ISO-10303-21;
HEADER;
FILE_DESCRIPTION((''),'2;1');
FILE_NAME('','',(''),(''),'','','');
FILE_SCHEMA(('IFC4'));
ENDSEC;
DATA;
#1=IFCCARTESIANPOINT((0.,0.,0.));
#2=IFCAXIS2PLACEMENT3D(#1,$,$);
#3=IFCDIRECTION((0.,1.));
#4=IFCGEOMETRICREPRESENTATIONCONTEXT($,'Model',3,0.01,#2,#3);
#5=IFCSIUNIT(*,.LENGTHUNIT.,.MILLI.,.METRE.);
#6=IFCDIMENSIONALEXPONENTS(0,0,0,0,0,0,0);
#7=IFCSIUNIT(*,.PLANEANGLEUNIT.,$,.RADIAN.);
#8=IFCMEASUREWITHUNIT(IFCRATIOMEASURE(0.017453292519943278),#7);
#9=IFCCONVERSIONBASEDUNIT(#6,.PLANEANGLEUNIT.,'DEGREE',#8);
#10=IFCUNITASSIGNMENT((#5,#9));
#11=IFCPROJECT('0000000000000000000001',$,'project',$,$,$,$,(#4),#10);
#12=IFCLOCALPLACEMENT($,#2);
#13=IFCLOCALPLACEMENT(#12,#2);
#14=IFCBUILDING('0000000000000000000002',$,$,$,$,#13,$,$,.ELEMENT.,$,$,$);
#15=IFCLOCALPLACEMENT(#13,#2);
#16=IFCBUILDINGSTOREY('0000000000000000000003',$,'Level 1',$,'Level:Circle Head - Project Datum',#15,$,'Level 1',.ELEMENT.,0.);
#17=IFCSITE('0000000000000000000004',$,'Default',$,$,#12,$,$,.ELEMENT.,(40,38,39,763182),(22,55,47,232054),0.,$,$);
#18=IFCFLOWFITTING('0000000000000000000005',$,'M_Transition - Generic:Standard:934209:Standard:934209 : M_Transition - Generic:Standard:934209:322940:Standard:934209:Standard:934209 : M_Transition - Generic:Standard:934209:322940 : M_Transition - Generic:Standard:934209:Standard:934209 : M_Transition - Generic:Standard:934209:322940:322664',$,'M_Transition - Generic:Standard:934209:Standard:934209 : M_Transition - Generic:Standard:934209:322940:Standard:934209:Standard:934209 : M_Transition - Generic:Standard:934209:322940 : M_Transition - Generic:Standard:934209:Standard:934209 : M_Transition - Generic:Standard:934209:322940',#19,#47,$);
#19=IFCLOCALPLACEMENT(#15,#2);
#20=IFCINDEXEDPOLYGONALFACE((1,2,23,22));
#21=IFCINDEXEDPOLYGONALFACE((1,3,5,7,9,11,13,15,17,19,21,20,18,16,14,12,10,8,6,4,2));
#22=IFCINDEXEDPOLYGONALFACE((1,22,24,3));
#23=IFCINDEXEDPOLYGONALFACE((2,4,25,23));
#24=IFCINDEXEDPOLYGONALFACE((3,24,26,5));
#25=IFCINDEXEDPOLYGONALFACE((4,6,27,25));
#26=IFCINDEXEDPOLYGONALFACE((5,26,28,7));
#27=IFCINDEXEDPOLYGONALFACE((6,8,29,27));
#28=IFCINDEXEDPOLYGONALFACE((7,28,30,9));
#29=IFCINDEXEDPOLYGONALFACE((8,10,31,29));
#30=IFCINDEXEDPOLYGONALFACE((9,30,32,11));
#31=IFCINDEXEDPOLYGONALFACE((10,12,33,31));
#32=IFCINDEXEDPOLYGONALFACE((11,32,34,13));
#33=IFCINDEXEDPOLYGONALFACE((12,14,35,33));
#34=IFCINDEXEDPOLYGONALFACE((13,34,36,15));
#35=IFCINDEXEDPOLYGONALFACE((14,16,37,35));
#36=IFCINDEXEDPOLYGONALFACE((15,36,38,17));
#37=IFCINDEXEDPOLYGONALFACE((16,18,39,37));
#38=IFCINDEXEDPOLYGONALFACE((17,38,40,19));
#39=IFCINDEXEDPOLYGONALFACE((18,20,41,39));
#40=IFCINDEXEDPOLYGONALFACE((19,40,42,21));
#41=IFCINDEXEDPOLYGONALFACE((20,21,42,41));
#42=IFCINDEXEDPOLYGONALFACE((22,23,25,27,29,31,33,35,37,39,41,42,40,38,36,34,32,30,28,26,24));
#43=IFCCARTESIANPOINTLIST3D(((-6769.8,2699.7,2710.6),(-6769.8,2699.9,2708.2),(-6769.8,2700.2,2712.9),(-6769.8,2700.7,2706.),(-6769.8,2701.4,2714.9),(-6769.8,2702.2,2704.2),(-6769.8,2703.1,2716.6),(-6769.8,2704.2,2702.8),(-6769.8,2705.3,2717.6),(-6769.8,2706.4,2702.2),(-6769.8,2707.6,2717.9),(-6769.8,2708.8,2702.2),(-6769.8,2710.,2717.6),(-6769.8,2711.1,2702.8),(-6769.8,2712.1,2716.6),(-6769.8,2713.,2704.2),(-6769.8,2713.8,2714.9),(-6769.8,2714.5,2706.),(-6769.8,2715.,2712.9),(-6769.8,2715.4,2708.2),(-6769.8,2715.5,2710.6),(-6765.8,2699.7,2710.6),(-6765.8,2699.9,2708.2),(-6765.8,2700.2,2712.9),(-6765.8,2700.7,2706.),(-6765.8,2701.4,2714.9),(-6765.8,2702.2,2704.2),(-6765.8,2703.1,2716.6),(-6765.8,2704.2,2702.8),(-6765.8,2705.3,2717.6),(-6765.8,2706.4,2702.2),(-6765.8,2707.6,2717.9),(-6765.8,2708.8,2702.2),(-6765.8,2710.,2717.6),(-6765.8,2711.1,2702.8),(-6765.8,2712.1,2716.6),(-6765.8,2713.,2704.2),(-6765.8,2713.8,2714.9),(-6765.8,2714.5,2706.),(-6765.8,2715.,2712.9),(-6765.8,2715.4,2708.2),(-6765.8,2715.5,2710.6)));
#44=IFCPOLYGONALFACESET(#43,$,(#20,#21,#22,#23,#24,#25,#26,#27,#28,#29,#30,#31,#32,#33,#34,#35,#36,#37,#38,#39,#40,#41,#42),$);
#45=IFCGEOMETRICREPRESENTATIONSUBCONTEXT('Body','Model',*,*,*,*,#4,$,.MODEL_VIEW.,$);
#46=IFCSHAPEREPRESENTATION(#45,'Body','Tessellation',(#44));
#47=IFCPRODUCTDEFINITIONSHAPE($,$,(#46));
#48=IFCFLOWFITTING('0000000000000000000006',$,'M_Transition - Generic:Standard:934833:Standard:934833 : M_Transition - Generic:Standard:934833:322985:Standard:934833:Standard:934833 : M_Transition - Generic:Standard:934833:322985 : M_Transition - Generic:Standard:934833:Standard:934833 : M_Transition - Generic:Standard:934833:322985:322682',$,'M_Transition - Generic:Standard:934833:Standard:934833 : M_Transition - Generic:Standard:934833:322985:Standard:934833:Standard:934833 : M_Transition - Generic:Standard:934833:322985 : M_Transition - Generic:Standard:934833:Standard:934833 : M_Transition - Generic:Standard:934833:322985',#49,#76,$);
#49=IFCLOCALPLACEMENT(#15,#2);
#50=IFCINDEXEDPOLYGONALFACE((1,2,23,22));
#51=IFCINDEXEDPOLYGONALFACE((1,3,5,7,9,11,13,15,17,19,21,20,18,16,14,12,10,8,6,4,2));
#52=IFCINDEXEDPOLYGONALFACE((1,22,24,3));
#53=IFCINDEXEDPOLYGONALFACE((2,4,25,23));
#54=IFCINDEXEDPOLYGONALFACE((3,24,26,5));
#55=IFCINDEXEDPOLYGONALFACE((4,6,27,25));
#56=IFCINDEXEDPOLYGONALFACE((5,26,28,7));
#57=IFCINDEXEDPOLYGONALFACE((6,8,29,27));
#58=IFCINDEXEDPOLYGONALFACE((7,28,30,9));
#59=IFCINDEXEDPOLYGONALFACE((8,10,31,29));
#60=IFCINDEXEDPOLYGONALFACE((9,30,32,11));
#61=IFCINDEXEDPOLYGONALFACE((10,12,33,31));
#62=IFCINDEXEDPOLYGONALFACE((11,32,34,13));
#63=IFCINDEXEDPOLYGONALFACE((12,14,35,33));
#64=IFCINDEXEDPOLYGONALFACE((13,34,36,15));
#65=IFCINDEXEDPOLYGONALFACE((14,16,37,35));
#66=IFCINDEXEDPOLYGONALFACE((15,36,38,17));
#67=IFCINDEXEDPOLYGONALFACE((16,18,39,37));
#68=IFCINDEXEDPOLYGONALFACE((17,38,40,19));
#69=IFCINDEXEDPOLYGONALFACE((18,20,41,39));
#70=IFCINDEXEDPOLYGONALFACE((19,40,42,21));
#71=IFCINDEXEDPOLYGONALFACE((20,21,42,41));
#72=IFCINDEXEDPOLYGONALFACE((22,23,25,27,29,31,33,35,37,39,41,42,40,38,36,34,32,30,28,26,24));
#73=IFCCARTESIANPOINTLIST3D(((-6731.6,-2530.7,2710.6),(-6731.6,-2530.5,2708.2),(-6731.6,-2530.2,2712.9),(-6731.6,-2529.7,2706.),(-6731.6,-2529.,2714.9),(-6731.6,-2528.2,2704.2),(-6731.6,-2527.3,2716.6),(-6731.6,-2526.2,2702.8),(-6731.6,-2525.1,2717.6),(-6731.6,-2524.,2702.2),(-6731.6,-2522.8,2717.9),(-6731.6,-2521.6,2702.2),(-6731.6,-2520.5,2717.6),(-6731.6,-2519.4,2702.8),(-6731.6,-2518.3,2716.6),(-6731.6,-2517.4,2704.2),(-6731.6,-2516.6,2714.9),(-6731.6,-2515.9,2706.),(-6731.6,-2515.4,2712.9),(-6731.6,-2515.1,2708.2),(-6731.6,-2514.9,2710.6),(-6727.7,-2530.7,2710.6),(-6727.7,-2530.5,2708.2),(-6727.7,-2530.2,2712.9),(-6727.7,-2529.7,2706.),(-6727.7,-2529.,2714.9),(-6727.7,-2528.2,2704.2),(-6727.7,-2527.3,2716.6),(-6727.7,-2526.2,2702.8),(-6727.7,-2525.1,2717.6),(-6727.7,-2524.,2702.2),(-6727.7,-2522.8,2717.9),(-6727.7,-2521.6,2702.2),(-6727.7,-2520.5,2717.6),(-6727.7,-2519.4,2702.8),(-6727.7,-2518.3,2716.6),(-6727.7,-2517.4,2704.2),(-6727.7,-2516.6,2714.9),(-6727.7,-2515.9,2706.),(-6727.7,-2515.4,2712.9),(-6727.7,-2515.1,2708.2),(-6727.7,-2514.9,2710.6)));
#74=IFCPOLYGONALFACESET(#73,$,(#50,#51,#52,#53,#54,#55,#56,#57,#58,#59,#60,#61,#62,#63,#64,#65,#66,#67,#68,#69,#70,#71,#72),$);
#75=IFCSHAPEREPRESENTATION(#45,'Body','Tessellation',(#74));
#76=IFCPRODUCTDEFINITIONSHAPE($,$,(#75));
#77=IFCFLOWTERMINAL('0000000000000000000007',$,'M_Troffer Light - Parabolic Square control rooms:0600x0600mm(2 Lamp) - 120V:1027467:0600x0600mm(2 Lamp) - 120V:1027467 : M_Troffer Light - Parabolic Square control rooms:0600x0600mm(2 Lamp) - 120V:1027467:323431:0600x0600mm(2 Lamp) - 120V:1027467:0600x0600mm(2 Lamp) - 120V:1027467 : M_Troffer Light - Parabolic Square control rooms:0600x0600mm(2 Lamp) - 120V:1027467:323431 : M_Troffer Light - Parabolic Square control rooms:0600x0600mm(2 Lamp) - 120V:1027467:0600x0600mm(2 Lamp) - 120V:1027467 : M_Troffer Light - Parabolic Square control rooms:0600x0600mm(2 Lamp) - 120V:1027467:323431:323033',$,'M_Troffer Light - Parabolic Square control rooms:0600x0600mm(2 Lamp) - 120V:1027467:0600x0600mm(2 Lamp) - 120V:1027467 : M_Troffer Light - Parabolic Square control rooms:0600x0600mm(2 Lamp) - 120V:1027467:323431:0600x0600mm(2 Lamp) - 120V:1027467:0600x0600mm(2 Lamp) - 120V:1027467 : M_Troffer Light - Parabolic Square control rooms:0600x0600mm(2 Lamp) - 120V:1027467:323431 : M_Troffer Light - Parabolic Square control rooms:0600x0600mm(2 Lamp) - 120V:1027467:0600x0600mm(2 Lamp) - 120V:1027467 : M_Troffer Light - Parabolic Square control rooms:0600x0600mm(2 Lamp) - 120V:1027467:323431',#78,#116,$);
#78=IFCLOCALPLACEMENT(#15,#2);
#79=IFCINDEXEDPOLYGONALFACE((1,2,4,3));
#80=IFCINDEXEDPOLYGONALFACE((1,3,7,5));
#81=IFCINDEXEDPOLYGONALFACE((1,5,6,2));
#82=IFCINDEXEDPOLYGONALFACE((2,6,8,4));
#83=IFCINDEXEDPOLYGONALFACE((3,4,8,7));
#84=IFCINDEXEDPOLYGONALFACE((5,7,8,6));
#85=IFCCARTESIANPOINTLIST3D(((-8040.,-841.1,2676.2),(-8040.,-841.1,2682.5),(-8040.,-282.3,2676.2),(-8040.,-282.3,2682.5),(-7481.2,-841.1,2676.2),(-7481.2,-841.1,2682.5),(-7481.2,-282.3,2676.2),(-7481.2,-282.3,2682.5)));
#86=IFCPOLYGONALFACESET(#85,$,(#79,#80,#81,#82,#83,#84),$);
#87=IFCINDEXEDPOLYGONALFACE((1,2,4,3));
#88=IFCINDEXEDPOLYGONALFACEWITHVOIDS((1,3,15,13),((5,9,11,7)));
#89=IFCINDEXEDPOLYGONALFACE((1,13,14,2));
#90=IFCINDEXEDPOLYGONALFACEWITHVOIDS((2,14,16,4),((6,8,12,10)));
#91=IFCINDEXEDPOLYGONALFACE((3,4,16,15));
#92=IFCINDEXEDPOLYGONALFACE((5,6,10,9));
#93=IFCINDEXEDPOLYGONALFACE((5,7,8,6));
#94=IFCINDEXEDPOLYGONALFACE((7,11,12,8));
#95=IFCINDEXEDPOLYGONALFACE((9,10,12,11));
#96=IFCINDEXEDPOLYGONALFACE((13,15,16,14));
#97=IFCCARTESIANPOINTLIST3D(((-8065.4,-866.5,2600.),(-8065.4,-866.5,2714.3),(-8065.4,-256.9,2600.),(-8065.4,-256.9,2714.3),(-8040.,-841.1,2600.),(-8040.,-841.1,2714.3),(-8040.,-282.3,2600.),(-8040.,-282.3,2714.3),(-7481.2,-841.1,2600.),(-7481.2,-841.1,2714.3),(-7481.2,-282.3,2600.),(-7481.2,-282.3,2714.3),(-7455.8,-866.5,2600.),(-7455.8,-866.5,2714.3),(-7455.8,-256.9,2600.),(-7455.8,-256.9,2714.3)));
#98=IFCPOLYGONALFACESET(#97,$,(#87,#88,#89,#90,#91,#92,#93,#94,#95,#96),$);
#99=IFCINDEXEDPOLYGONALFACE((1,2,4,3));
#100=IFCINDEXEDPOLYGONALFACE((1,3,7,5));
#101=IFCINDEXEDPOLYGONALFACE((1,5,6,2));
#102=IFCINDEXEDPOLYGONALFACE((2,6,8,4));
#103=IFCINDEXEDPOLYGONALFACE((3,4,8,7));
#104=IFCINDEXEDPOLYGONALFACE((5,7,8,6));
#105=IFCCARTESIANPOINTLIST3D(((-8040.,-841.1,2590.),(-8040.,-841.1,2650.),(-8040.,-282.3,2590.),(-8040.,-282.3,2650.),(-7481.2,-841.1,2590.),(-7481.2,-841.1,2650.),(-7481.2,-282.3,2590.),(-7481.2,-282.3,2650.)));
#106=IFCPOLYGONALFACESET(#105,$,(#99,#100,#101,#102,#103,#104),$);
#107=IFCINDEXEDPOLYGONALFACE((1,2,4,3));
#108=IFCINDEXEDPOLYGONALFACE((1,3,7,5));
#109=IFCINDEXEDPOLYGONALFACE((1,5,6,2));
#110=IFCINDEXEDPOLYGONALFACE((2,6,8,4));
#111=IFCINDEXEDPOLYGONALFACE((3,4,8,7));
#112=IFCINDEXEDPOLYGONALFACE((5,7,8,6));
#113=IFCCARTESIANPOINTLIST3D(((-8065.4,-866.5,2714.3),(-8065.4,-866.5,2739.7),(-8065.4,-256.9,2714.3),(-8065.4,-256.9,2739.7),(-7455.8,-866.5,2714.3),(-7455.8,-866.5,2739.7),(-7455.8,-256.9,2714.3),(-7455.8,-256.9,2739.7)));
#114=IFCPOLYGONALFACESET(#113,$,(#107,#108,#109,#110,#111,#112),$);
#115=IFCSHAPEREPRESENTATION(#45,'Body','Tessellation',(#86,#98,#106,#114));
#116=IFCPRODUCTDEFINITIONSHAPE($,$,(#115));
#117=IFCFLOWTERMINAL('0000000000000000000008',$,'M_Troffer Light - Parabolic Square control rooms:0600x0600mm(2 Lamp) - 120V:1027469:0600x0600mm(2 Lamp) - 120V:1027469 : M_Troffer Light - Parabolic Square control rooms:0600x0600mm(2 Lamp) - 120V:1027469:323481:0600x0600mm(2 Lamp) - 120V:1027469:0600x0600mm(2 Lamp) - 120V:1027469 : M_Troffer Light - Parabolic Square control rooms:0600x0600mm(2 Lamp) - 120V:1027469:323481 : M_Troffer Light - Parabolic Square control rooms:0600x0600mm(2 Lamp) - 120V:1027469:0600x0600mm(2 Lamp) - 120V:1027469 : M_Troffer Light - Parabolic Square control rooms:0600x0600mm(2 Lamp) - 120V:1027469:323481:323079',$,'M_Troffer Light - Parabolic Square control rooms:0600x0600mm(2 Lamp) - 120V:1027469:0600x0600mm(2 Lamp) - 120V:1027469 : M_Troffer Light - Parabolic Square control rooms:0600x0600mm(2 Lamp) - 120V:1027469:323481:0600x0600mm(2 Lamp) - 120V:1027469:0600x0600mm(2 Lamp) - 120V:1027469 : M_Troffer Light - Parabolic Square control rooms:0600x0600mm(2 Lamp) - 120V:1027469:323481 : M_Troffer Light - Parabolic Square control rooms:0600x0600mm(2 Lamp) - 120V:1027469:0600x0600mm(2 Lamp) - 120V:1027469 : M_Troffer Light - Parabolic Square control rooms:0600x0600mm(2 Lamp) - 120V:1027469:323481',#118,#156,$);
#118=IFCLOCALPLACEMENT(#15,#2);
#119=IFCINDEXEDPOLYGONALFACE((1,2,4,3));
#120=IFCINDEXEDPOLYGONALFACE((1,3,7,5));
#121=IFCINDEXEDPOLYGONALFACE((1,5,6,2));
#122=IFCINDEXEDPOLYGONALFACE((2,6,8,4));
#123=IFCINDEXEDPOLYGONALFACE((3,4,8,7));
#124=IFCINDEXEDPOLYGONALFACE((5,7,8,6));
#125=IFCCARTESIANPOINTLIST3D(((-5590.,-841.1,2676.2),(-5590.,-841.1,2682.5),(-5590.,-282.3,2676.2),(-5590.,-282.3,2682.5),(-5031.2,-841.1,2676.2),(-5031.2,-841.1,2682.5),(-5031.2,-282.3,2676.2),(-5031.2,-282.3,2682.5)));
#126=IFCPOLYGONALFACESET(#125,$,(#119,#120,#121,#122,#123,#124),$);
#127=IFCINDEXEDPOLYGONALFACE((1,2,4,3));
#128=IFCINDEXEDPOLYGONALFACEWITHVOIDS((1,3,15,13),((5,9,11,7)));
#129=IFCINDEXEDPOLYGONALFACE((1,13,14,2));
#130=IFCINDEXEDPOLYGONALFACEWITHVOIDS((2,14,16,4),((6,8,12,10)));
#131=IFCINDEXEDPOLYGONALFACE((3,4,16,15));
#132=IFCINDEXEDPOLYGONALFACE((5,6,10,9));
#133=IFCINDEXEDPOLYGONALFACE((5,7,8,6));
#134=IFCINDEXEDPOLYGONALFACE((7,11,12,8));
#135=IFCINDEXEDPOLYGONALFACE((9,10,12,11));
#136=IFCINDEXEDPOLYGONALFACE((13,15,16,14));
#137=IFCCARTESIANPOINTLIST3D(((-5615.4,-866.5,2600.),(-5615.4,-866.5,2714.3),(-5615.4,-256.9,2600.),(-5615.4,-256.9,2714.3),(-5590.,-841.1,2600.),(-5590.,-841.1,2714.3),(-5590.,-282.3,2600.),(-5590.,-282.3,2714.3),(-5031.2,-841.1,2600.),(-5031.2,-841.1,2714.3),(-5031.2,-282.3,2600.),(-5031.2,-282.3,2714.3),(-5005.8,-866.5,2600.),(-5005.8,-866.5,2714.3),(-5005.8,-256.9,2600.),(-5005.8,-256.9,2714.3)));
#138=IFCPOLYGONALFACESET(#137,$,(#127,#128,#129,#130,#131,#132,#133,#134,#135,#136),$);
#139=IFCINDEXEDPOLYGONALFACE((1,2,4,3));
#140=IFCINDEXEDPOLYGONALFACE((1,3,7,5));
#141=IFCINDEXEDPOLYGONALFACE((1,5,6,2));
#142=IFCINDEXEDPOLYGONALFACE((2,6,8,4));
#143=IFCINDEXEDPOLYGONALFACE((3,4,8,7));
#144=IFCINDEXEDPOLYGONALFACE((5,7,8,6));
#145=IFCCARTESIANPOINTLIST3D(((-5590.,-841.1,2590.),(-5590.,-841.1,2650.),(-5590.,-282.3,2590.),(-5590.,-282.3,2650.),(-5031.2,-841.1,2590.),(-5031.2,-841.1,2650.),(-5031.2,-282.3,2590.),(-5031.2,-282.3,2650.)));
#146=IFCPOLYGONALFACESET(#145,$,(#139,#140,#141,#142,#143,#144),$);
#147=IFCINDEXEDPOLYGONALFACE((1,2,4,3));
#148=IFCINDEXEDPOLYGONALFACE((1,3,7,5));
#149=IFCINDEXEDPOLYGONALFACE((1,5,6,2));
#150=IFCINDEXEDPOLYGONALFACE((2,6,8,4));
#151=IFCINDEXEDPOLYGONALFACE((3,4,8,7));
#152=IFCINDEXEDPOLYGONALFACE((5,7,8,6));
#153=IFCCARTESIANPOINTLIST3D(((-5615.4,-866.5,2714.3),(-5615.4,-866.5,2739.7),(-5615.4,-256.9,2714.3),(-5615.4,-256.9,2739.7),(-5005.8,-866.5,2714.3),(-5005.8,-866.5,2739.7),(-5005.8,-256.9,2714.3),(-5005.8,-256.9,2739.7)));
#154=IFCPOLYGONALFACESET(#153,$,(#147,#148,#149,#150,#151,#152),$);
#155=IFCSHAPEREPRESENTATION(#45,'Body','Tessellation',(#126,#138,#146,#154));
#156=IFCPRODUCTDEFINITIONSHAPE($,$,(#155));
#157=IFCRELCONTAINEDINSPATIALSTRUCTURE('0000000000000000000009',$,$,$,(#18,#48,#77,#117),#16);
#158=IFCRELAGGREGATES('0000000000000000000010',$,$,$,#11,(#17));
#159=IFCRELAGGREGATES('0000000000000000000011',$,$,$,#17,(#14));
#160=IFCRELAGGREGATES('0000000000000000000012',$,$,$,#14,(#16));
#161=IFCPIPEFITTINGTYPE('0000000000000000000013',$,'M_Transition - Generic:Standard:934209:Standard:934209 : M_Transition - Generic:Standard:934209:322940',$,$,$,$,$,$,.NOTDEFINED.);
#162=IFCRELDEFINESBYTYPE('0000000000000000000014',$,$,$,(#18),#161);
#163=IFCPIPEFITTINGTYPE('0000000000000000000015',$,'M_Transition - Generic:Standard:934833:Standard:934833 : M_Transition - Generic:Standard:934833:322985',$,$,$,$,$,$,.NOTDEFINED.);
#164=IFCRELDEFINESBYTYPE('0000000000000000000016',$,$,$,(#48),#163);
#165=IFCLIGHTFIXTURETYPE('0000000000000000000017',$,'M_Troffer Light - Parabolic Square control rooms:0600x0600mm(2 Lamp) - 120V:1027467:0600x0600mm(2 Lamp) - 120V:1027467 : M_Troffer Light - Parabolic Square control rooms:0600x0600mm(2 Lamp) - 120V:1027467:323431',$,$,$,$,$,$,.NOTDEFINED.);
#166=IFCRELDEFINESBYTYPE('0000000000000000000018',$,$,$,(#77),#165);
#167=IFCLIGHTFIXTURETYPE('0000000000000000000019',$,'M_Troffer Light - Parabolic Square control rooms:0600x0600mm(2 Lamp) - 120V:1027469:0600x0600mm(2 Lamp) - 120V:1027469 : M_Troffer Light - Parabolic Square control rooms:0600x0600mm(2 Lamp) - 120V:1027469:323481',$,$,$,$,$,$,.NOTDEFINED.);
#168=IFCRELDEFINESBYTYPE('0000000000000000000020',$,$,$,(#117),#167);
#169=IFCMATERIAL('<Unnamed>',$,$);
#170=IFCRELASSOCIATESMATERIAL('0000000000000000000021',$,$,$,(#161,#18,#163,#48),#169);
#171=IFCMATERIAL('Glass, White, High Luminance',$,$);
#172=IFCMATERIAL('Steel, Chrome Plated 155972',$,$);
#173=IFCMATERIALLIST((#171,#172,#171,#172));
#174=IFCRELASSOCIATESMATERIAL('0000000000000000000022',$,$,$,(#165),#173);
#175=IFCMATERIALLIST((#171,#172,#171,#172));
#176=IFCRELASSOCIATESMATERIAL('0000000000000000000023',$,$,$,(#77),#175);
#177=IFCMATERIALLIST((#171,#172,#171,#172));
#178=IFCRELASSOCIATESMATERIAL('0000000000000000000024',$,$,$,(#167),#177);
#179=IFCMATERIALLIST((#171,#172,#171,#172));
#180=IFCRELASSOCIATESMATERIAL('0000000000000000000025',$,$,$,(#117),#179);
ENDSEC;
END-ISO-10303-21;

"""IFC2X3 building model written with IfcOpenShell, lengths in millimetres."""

from ifc_helpers import new_model, entity, si_unit, converted_unit, direction, frame, frame_2d, origin, origin_2d_with_axis, place, context, subcontext, project, spatial, polyline, rectangle, circle, outline, extrude, source, transform, mapped, material, material_list, type_object, type_shapes, element, save


model = new_model("IFC2X3")

# Units and contexts
model_context = context("Model", 3, precision=0.01, world=origin(), true_north=direction((0.0, 1.0)))
body_context = subcontext(model_context, "Body", "Model", "MODEL_VIEW")
ifc_project = project(units=[si_unit("LENGTHUNIT", "METRE", prefix="MILLI"), converted_unit("PLANEANGLEUNIT", "DEGREE", entity("IfcRatioMeasure", 0.017453292519943278), si_unit("PLANEANGLEUNIT", "RADIAN"), dimensions=[0, 0, 0, 0, 0, 0, 0])], contexts=[model_context])

# Site, building, storey
site_placement = place(None, origin())
site = spatial("IfcSite", under=ifc_project, at=site_placement, Name="Default", CompositionType="ELEMENT", RefLatitude=(40, 38, 39, 763182), RefLongitude=(22, 55, 47, 232054), RefElevation=0.0)
building_placement = place(site_placement, origin())
building = spatial("IfcBuilding", under=site, at=building_placement, CompositionType="ELEMENT")
storey_placement = place(building_placement, origin())
storey = spatial("IfcBuildingStorey", under=building, at=storey_placement, Name="Level 1", ObjectType="Level:Circle Head - Project Datum", LongName="Level 1", CompositionType="ELEMENT", Elevation=0.0)

# Flow fittings
ifc_material_1 = material(Name="<Unnamed>")
pipe_fitting_type_1 = type_object("IfcPipeFittingType", Name="M_Transition - Generic:Standard:934209:Standard:934209 : M_Transition - Generic:Standard:934209:322940", PredefinedType="NOTDEFINED", material=ifc_material_1)
shared_shape_1 = source(origin(), body_context, "Body", "SweptSolid", [
    extrude(circle(Radius=7.9, at=origin_2d_with_axis()), frame((-6769.8, 2707.6, 2710.0), z_axis=(1.0, 0.0, 0.0), x_axis=(0.0, 0.0, 1.0)), (0.0, 0.0, 1.0), 4.0),
])
type_shapes(pipe_fitting_type_1, [shared_shape_1])
flow_fitting_1_placement = place(storey_placement, origin())
element("IfcFlowFitting", 1, at=flow_fitting_1_placement, inside=storey, type_object=pipe_fitting_type_1, material=ifc_material_1, Name="M_Transition - Generic:Standard:934209:Standard:934209 : M_Transition - Generic:Standard:934209:322940:Standard:934209:Standard:934209 : M_Transition - Generic:Standard:934209:322940 : M_Transition - Generic:Standard:934209:Standard:934209 : M_Transition - Generic:Standard:934209:322940:322664", ObjectType="M_Transition - Generic:Standard:934209:Standard:934209 : M_Transition - Generic:Standard:934209:322940:Standard:934209:Standard:934209 : M_Transition - Generic:Standard:934209:322940 : M_Transition - Generic:Standard:934209:Standard:934209 : M_Transition - Generic:Standard:934209:322940", context=body_context, shape_type="MappedRepresentation", body=[
    mapped(shared_shape_1, transform((0.0, 0.0, 0.0), scale=1.0)),
])
pipe_fitting_type_2 = type_object("IfcPipeFittingType", Name="M_Transition - Generic:Standard:934833:Standard:934833 : M_Transition - Generic:Standard:934833:322985", PredefinedType="NOTDEFINED", material=ifc_material_1)
shared_shape_2 = source(origin(), body_context, "Body", "SweptSolid", [
    extrude(circle(Radius=7.9, at=origin_2d_with_axis()), frame((-6731.6, -2522.8, 2710.0), z_axis=(1.0, 0.0, 0.0), x_axis=(0.0, 0.0, 1.0)), (0.0, 0.0, 1.0), 4.0),
])
type_shapes(pipe_fitting_type_2, [shared_shape_2])
flow_fitting_2_placement = place(storey_placement, origin())
element("IfcFlowFitting", 2, at=flow_fitting_2_placement, inside=storey, type_object=pipe_fitting_type_2, material=ifc_material_1, Name="M_Transition - Generic:Standard:934833:Standard:934833 : M_Transition - Generic:Standard:934833:322985:Standard:934833:Standard:934833 : M_Transition - Generic:Standard:934833:322985 : M_Transition - Generic:Standard:934833:Standard:934833 : M_Transition - Generic:Standard:934833:322985:322682", ObjectType="M_Transition - Generic:Standard:934833:Standard:934833 : M_Transition - Generic:Standard:934833:322985:Standard:934833:Standard:934833 : M_Transition - Generic:Standard:934833:322985 : M_Transition - Generic:Standard:934833:Standard:934833 : M_Transition - Generic:Standard:934833:322985", context=body_context, shape_type="MappedRepresentation", body=[
    mapped(shared_shape_2, transform((0.0, 0.0, 0.0), scale=1.0)),
])

# Flow terminals
ifc_material_2 = material(Name="Glass, White, High Luminance")
ifc_material_3 = material(Name="Steel, Chrome Plated 155972")
ifc_material_list_1 = material_list([ifc_material_2, ifc_material_3, ifc_material_2, ifc_material_3])
ifc_material_list_2 = material_list([ifc_material_2, ifc_material_3, ifc_material_2, ifc_material_3])
light_fixture_type_1 = type_object("IfcLightFixtureType", Name="M_Troffer Light - Parabolic Square control rooms:0600x0600mm(2 Lamp) - 120V:1027467:0600x0600mm(2 Lamp) - 120V:1027467 : M_Troffer Light - Parabolic Square control rooms:0600x0600mm(2 Lamp) - 120V:1027467:323431", PredefinedType="NOTDEFINED", material=ifc_material_list_2)
shared_shape_3 = source(origin(), body_context, "Body", "SweptSolid", [
    extrude(rectangle(XDim=558.8, YDim=558.8, at=frame_2d((0.0, 0.0), x_axis=(1.0, 0.0))), frame((-7760.6, -561.7, 2676.2), z_axis=(0.0, 0.0, 1.0), x_axis=(0.0, 1.0, 0.0)), (0.0, 0.0, 1.0), 6.4),
    extrude(outline(polyline([(-304.8, -304.8), (304.8, -304.8), (304.8, 304.8), (-304.8, 304.8), (-304.8, -304.8)]), holes=[polyline([(279.4, 279.4), (279.4, -279.4), (-279.4, -279.4), (-279.4, 279.4), (279.4, 279.4)])]), frame((-7760.6, -561.7, 2600.0), z_axis=(0.0, 0.0, 1.0), x_axis=(0.0, -1.0, 0.0)), (0.0, 0.0, 1.0), 114.3),
    extrude(rectangle(XDim=558.8, YDim=558.8, at=frame_2d((0.0, 0.0), x_axis=(1.0, 0.0))), frame((-7760.6, -561.7, 2590.0), z_axis=(0.0, 0.0, 1.0), x_axis=(0.0, 1.0, 0.0)), (0.0, 0.0, 1.0), 60.0),
    extrude(rectangle(XDim=609.6, YDim=609.6, at=origin_2d_with_axis()), frame((-7760.6, -561.7, 2714.3), z_axis=(0.0, 0.0, 1.0), x_axis=(0.0, 1.0, 0.0)), (0.0, 0.0, 1.0), 25.4),
])
type_shapes(light_fixture_type_1, [shared_shape_3])
flow_terminal_1_placement = place(storey_placement, origin())
element("IfcFlowTerminal", 3, at=flow_terminal_1_placement, inside=storey, type_object=light_fixture_type_1, material=ifc_material_list_1, Name="M_Troffer Light - Parabolic Square control rooms:0600x0600mm(2 Lamp) - 120V:1027467:0600x0600mm(2 Lamp) - 120V:1027467 : M_Troffer Light - Parabolic Square control rooms:0600x0600mm(2 Lamp) - 120V:1027467:323431:0600x0600mm(2 Lamp) - 120V:1027467:0600x0600mm(2 Lamp) - 120V:1027467 : M_Troffer Light - Parabolic Square control rooms:0600x0600mm(2 Lamp) - 120V:1027467:323431 : M_Troffer Light - Parabolic Square control rooms:0600x0600mm(2 Lamp) - 120V:1027467:0600x0600mm(2 Lamp) - 120V:1027467 : M_Troffer Light - Parabolic Square control rooms:0600x0600mm(2 Lamp) - 120V:1027467:323431:323033", ObjectType="M_Troffer Light - Parabolic Square control rooms:0600x0600mm(2 Lamp) - 120V:1027467:0600x0600mm(2 Lamp) - 120V:1027467 : M_Troffer Light - Parabolic Square control rooms:0600x0600mm(2 Lamp) - 120V:1027467:323431:0600x0600mm(2 Lamp) - 120V:1027467:0600x0600mm(2 Lamp) - 120V:1027467 : M_Troffer Light - Parabolic Square control rooms:0600x0600mm(2 Lamp) - 120V:1027467:323431 : M_Troffer Light - Parabolic Square control rooms:0600x0600mm(2 Lamp) - 120V:1027467:0600x0600mm(2 Lamp) - 120V:1027467 : M_Troffer Light - Parabolic Square control rooms:0600x0600mm(2 Lamp) - 120V:1027467:323431", context=body_context, shape_type="MappedRepresentation", body=[
    mapped(shared_shape_3, transform((0.0, 0.0, 0.0), scale=1.0)),
])
ifc_material_list_3 = material_list([ifc_material_2, ifc_material_3, ifc_material_2, ifc_material_3])
ifc_material_list_4 = material_list([ifc_material_2, ifc_material_3, ifc_material_2, ifc_material_3])
light_fixture_type_2 = type_object("IfcLightFixtureType", Name="M_Troffer Light - Parabolic Square control rooms:0600x0600mm(2 Lamp) - 120V:1027469:0600x0600mm(2 Lamp) - 120V:1027469 : M_Troffer Light - Parabolic Square control rooms:0600x0600mm(2 Lamp) - 120V:1027469:323481", PredefinedType="NOTDEFINED", material=ifc_material_list_4)
shared_shape_4 = source(origin(), body_context, "Body", "SweptSolid", [
    extrude(rectangle(XDim=558.8, YDim=558.8, at=frame_2d((0.0, 0.0), x_axis=(1.0, 0.0))), frame((-5310.6, -561.7, 2676.2), z_axis=(0.0, 0.0, 1.0), x_axis=(0.0, 1.0, 0.0)), (0.0, 0.0, 1.0), 6.4),
    extrude(outline(polyline([(-304.8, -304.8), (304.8, -304.8), (304.8, 304.8), (-304.8, 304.8), (-304.8, -304.8)]), holes=[polyline([(279.4, 279.4), (279.4, -279.4), (-279.4, -279.4), (-279.4, 279.4), (279.4, 279.4)])]), frame((-5310.6, -561.7, 2600.0), z_axis=(0.0, 0.0, 1.0), x_axis=(0.0, -1.0, 0.0)), (0.0, 0.0, 1.0), 114.3),
    extrude(rectangle(XDim=558.8, YDim=558.8, at=frame_2d((0.0, 0.0), x_axis=(1.0, 0.0))), frame((-5310.6, -561.7, 2590.0), z_axis=(0.0, 0.0, 1.0), x_axis=(0.0, 1.0, 0.0)), (0.0, 0.0, 1.0), 60.0),
    extrude(rectangle(XDim=609.6, YDim=609.6, at=origin_2d_with_axis()), frame((-5310.6, -561.7, 2714.3), z_axis=(0.0, 0.0, 1.0), x_axis=(0.0, 1.0, 0.0)), (0.0, 0.0, 1.0), 25.4),
])
type_shapes(light_fixture_type_2, [shared_shape_4])
flow_terminal_2_placement = place(storey_placement, origin())
element("IfcFlowTerminal", 4, at=flow_terminal_2_placement, inside=storey, type_object=light_fixture_type_2, material=ifc_material_list_3, Name="M_Troffer Light - Parabolic Square control rooms:0600x0600mm(2 Lamp) - 120V:1027469:0600x0600mm(2 Lamp) - 120V:1027469 : M_Troffer Light - Parabolic Square control rooms:0600x0600mm(2 Lamp) - 120V:1027469:323481:0600x0600mm(2 Lamp) - 120V:1027469:0600x0600mm(2 Lamp) - 120V:1027469 : M_Troffer Light - Parabolic Square control rooms:0600x0600mm(2 Lamp) - 120V:1027469:323481 : M_Troffer Light - Parabolic Square control rooms:0600x0600mm(2 Lamp) - 120V:1027469:0600x0600mm(2 Lamp) - 120V:1027469 : M_Troffer Light - Parabolic Square control rooms:0600x0600mm(2 Lamp) - 120V:1027469:323481:323079", ObjectType="M_Troffer Light - Parabolic Square control rooms:0600x0600mm(2 Lamp) - 120V:1027469:0600x0600mm(2 Lamp) - 120V:1027469 : M_Troffer Light - Parabolic Square control rooms:0600x0600mm(2 Lamp) - 120V:1027469:323481:0600x0600mm(2 Lamp) - 120V:1027469:0600x0600mm(2 Lamp) - 120V:1027469 : M_Troffer Light - Parabolic Square control rooms:0600x0600mm(2 Lamp) - 120V:1027469:323481 : M_Troffer Light - Parabolic Square control rooms:0600x0600mm(2 Lamp) - 120V:1027469:0600x0600mm(2 Lamp) - 120V:1027469 : M_Troffer Light - Parabolic Square control rooms:0600x0600mm(2 Lamp) - 120V:1027469:323481", context=body_context, shape_type="MappedRepresentation", body=[
    mapped(shared_shape_4, transform((0.0, 0.0, 0.0), scale=1.0)),
])

save(model, "model.ifc")
